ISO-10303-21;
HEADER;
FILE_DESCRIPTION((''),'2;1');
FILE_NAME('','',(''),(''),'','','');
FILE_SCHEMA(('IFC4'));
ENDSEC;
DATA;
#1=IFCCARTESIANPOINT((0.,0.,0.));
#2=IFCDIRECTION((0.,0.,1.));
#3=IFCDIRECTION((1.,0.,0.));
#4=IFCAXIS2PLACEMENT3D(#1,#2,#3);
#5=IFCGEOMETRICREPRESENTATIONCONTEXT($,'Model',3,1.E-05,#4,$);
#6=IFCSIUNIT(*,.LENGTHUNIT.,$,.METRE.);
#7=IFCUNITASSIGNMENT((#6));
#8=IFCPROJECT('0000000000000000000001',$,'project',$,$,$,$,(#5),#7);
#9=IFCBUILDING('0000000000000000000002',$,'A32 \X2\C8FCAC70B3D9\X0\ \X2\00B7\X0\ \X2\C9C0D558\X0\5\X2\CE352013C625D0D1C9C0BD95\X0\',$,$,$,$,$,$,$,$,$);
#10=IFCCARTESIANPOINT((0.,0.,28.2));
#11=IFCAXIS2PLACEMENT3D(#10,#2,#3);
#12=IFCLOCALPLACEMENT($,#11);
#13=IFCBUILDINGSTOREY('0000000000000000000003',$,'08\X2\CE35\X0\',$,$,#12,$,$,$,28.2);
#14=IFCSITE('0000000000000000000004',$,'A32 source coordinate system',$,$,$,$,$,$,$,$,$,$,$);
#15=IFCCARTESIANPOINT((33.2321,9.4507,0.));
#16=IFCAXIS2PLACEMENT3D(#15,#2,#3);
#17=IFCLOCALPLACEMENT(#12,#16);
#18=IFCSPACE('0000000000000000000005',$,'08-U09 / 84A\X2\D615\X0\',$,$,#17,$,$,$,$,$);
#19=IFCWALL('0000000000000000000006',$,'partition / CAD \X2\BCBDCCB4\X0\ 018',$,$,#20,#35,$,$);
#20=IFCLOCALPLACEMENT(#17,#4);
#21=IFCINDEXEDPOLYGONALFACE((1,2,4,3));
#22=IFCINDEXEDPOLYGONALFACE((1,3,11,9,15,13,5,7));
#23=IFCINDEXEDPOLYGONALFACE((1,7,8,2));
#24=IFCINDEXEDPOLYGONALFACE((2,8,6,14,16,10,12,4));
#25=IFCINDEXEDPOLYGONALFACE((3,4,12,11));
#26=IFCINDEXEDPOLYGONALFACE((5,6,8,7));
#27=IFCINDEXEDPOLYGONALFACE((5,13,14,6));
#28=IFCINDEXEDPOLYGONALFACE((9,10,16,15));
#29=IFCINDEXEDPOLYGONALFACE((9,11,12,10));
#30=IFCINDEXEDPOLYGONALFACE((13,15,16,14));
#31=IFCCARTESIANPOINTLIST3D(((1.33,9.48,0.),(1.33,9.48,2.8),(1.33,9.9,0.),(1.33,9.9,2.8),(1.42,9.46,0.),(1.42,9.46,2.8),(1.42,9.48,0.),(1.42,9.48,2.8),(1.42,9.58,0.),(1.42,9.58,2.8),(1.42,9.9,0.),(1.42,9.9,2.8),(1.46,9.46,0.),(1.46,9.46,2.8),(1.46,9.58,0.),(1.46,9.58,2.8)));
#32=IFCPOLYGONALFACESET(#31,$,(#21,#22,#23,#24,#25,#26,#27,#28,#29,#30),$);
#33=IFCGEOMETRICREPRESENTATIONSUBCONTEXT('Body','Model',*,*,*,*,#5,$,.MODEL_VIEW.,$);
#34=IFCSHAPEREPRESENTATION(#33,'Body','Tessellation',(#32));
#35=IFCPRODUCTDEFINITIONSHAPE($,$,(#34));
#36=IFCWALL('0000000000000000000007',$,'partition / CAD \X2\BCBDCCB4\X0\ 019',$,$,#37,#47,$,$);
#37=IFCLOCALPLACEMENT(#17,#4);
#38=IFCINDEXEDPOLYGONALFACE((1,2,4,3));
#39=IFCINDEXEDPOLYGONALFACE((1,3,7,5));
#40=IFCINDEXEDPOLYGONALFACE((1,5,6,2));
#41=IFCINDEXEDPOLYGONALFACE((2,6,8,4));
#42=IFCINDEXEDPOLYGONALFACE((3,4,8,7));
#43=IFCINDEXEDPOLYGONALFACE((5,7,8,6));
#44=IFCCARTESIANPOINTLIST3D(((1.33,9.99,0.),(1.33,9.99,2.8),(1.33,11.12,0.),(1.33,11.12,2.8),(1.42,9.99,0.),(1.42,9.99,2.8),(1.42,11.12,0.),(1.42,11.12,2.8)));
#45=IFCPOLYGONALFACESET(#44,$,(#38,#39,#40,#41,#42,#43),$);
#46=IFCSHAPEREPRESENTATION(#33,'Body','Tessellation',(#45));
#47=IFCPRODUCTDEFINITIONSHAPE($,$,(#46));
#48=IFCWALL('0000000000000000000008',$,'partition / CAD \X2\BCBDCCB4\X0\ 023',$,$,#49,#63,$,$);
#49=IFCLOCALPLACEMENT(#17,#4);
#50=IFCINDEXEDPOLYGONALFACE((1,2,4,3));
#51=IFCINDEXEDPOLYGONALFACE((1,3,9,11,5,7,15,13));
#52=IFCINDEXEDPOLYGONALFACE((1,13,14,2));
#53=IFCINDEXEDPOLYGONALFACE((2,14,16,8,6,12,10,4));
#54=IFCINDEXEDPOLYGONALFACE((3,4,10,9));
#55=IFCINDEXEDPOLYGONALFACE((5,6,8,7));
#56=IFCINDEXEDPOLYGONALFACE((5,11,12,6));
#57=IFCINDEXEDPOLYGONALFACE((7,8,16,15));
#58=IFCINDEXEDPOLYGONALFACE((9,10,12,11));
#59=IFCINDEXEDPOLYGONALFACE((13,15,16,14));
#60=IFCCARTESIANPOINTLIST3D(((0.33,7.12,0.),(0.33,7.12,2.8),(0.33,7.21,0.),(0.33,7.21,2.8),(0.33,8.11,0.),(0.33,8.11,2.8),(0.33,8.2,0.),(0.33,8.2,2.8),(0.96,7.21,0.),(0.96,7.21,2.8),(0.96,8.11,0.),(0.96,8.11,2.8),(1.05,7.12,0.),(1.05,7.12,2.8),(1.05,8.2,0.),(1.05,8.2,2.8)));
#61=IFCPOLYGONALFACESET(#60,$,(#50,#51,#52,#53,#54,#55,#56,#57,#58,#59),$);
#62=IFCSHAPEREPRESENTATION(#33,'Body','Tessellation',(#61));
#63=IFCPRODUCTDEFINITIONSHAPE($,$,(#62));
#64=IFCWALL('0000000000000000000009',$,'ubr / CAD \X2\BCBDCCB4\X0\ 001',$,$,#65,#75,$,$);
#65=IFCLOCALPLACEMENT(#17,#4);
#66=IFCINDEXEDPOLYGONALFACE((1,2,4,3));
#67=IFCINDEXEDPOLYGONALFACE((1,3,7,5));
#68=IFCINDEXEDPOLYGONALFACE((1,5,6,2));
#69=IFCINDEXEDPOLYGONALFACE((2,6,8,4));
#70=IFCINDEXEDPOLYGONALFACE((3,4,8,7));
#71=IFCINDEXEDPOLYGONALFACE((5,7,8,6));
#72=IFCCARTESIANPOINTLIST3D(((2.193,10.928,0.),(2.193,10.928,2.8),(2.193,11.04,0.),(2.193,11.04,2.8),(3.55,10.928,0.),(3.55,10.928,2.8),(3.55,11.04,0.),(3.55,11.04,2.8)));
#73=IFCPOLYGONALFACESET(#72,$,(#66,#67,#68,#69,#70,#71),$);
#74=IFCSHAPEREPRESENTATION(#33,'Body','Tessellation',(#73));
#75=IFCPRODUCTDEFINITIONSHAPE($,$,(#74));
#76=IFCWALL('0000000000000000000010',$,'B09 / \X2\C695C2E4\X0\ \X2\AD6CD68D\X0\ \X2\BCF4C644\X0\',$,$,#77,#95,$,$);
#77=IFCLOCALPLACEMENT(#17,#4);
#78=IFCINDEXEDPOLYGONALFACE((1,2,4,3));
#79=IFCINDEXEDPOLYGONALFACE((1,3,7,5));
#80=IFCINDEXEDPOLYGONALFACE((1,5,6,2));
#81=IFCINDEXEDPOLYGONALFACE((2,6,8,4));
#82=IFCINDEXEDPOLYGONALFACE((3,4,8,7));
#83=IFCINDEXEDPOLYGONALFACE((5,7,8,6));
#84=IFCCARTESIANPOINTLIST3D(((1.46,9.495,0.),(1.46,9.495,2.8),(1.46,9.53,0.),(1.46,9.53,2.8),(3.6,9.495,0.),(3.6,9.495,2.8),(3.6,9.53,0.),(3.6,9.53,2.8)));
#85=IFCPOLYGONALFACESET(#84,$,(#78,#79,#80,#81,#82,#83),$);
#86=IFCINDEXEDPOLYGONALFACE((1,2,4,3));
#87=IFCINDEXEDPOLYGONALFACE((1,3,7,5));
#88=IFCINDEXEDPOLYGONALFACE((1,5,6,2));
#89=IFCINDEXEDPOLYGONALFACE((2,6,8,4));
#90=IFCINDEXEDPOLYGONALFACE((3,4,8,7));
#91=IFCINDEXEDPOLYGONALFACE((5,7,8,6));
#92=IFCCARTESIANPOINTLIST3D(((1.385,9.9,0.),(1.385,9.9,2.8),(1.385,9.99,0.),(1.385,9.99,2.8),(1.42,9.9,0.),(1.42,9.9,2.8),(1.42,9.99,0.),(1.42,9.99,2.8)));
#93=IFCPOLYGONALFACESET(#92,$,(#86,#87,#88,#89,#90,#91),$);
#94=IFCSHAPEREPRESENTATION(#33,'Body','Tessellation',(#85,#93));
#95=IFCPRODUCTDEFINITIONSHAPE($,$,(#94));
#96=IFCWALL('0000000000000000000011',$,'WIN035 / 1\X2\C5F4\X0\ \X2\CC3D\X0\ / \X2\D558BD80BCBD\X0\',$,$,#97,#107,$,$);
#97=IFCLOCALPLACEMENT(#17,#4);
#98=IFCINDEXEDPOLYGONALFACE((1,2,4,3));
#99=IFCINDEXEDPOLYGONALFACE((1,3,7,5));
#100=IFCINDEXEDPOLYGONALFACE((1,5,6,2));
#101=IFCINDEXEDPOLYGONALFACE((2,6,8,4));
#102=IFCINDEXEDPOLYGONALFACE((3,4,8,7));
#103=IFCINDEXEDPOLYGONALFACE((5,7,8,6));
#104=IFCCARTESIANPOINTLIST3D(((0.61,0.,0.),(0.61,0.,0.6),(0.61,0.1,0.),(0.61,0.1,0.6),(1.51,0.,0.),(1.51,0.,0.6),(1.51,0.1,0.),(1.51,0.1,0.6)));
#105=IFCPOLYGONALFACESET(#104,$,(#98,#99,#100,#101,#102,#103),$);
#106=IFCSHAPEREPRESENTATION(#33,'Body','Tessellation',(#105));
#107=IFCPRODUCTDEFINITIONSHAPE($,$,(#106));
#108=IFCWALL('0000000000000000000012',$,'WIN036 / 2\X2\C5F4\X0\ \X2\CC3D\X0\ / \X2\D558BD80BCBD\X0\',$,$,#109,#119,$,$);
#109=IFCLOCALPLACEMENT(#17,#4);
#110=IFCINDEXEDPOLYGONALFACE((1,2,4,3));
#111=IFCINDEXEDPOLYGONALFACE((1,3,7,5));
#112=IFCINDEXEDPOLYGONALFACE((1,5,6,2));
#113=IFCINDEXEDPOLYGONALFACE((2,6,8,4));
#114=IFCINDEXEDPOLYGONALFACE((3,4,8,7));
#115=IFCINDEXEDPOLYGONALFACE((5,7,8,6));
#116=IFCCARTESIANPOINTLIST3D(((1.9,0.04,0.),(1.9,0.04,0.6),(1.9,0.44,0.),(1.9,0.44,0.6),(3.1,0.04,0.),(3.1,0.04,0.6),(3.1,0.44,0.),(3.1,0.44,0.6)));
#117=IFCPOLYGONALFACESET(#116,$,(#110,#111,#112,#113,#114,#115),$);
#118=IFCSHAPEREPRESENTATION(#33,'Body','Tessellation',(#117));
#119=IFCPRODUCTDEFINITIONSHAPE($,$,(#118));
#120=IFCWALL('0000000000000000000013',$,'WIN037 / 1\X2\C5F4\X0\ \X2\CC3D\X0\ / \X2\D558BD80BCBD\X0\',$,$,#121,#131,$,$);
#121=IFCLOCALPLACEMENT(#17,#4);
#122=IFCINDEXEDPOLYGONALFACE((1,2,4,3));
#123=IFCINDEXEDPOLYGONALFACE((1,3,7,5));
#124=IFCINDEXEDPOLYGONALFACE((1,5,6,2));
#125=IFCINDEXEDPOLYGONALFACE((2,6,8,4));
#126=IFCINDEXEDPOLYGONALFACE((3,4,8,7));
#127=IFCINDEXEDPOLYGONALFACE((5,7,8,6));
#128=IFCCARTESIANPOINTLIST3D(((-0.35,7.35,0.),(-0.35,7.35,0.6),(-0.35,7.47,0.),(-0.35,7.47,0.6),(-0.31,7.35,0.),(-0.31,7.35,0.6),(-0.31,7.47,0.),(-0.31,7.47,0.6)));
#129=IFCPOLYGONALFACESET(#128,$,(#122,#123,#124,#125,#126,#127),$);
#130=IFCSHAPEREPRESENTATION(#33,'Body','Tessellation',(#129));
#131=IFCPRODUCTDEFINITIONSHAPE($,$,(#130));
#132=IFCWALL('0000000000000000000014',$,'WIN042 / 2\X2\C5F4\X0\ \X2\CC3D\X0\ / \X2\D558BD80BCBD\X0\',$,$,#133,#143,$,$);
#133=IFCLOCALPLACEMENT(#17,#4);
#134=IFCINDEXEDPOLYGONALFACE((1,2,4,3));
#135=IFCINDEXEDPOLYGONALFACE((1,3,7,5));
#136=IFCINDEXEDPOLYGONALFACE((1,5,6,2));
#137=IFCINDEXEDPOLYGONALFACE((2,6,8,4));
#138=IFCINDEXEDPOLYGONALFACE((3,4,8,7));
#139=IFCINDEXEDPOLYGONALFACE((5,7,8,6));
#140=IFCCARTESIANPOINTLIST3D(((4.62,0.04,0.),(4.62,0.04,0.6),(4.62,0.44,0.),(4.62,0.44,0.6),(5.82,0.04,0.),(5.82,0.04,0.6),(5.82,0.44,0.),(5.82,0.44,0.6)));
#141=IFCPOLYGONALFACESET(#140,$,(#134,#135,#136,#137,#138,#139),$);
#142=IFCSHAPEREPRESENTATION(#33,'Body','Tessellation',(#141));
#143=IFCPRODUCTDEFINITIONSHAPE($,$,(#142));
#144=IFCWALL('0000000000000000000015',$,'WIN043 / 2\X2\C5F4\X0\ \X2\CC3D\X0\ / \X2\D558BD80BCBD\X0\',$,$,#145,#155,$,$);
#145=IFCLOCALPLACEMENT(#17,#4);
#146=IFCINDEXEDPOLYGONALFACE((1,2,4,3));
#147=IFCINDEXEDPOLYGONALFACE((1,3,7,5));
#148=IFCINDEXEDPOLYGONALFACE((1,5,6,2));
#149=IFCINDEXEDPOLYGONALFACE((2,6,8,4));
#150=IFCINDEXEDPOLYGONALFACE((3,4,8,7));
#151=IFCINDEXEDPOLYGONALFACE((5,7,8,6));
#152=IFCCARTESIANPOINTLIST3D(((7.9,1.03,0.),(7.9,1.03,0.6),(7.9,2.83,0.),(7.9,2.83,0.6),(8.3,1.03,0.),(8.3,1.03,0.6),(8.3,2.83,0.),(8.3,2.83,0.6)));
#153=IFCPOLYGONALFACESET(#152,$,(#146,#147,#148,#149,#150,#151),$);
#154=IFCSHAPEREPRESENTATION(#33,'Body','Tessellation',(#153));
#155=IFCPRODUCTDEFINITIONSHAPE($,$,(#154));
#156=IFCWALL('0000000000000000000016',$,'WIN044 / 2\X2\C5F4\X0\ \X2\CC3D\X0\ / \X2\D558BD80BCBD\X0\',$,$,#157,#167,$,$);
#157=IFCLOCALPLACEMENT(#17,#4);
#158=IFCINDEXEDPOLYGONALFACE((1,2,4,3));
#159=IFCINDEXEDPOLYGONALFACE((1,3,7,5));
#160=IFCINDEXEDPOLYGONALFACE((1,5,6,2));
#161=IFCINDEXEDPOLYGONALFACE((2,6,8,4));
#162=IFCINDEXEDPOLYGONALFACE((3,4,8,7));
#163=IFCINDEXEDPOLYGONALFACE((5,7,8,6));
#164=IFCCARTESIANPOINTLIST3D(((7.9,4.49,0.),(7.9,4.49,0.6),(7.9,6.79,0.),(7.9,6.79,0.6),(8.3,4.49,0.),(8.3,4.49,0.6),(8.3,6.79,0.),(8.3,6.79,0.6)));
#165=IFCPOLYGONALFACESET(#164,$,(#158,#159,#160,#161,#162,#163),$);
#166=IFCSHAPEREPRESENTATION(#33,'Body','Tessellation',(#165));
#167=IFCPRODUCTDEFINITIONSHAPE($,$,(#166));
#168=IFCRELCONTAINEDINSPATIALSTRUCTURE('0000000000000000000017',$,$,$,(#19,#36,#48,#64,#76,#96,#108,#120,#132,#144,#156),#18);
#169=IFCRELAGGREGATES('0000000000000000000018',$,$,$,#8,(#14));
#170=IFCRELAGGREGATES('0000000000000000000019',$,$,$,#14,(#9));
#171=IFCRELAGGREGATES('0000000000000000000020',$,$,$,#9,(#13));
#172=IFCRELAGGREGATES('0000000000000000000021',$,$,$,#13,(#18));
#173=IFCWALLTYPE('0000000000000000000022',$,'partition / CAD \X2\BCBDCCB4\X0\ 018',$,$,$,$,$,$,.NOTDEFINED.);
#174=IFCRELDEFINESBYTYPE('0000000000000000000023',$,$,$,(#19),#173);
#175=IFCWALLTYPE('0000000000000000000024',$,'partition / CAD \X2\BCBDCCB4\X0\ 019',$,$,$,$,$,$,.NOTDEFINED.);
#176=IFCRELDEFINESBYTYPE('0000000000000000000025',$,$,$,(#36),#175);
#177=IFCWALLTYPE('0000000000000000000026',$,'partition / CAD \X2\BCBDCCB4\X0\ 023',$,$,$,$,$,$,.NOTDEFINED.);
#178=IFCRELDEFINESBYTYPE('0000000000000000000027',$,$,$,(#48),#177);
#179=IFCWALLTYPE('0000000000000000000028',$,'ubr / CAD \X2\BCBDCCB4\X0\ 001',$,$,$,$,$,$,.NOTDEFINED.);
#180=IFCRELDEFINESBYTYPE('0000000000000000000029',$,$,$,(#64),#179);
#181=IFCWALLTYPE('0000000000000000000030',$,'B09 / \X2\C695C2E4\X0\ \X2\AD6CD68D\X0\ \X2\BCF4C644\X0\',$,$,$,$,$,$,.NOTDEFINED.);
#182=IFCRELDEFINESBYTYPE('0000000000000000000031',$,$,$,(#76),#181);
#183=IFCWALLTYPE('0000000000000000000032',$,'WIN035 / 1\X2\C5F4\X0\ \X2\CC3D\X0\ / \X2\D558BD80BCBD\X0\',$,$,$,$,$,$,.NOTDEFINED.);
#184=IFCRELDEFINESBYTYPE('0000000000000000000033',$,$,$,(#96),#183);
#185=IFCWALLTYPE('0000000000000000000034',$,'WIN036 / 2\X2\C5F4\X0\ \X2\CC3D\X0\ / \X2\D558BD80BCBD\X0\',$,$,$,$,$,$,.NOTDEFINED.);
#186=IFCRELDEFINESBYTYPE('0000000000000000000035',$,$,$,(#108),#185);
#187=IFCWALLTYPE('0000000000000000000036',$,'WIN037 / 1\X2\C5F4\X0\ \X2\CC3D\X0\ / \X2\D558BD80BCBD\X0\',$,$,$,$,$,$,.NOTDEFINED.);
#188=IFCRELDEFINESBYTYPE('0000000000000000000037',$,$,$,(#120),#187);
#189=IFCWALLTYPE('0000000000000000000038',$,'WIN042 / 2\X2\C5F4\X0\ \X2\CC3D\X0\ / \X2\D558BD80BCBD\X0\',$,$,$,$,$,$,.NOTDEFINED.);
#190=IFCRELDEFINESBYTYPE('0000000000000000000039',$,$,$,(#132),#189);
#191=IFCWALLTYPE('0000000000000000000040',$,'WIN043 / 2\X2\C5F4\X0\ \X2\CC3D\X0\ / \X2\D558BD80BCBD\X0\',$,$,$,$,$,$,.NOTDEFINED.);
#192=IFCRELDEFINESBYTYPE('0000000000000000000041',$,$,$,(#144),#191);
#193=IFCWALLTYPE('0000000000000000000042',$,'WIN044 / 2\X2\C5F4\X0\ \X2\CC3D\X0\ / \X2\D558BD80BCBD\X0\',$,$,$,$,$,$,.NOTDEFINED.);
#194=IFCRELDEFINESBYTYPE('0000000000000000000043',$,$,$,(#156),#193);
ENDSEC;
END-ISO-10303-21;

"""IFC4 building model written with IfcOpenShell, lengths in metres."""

from ifc_helpers import new_model, si_unit, frame, origin, origin_with_axes, place, context, subcontext, project, spatial, polyline, outline, extrude, source, transform, mapped, type_object, type_shapes, element, save


model = new_model("IFC4")

# Units and contexts
model_context = context("Model", 3, precision=1e-05, world=origin_with_axes())
body_context = subcontext(model_context, "Body", "Model", "MODEL_VIEW")
ifc_project = project(units=[si_unit("LENGTHUNIT", "METRE")], contexts=[model_context])

# Site, building, storey, space
site = spatial("IfcSite", under=ifc_project, Name="A32 source coordinate system")
building = spatial("IfcBuilding", under=site, Name="A32 주거동 · 지하5층–옥탑지붕")
storey_placement = place(None, frame((0.0, 0.0, 28.2), z_axis=(0.0, 0.0, 1.0), x_axis=(1.0, 0.0, 0.0)))
storey = spatial("IfcBuildingStorey", under=building, at=storey_placement, Name="08층", Elevation=28.2)
space_1_placement = place(storey_placement, frame((33.2321, 9.4507, 0.0), z_axis=(0.0, 0.0, 1.0), x_axis=(1.0, 0.0, 0.0)))
space_1 = spatial("IfcSpace", under=storey, at=space_1_placement, Name="08-U09 / 84A형")

# Walls
wall_type_1 = type_object("IfcWallType", Name="partition / CAD 벽체 018", PredefinedType="NOTDEFINED")
shared_shape_1 = source(origin(), body_context, "Body", "SweptSolid", [
    extrude(outline(polyline([(1.42, 9.58), (1.46, 9.58), (1.46, 9.46), (1.42, 9.46), (1.42, 9.48), (1.33, 9.48), (1.33, 9.9), (1.42, 9.9), (1.42, 9.58)])), origin(), (0.0, 0.0, 1.0), 2.8),
])
type_shapes(wall_type_1, [shared_shape_1])
wall_1_placement = place(space_1_placement, origin_with_axes())
element("IfcWall", 1, at=wall_1_placement, inside=space_1, type_object=wall_type_1, Name="partition / CAD 벽체 018", context=body_context, shape_type="MappedRepresentation", body=[
    mapped(shared_shape_1, transform((0.0, 0.0, 0.0), scale=1.0)),
])
wall_type_2 = type_object("IfcWallType", Name="partition / CAD 벽체 019", PredefinedType="NOTDEFINED")
shared_shape_2 = source(origin(), body_context, "Body", "SweptSolid", [
    extrude(outline(polyline([(1.33, 11.12), (1.42, 11.12), (1.42, 9.99), (1.33, 9.99), (1.33, 11.12)])), origin(), (0.0, 0.0, 1.0), 2.8),
])
type_shapes(wall_type_2, [shared_shape_2])
wall_2_placement = place(space_1_placement, origin_with_axes())
element("IfcWall", 2, at=wall_2_placement, inside=space_1, type_object=wall_type_2, Name="partition / CAD 벽체 019", context=body_context, shape_type="MappedRepresentation", body=[
    mapped(shared_shape_2, transform((0.0, 0.0, 0.0), scale=1.0)),
])
wall_type_3 = type_object("IfcWallType", Name="partition / CAD 벽체 023", PredefinedType="NOTDEFINED")
shared_shape_3 = source(origin(), body_context, "Body", "SweptSolid", [
    extrude(outline(polyline([(0.96, 8.11), (0.33, 8.11), (0.33, 8.2), (1.05, 8.2), (1.05, 7.12), (0.33, 7.12), (0.33, 7.21), (0.96, 7.21), (0.96, 8.11)])), origin(), (0.0, 0.0, 1.0), 2.8),
])
type_shapes(wall_type_3, [shared_shape_3])
wall_3_placement = place(space_1_placement, origin_with_axes())
element("IfcWall", 3, at=wall_3_placement, inside=space_1, type_object=wall_type_3, Name="partition / CAD 벽체 023", context=body_context, shape_type="MappedRepresentation", body=[
    mapped(shared_shape_3, transform((0.0, 0.0, 0.0), scale=1.0)),
])
wall_type_4 = type_object("IfcWallType", Name="ubr / CAD 벽체 001", PredefinedType="NOTDEFINED")
shared_shape_4 = source(origin(), body_context, "Body", "SweptSolid", [
    extrude(outline(polyline([(3.55, 11.04), (3.55, 10.928), (2.193, 10.928), (2.193, 11.04), (3.55, 11.04)])), origin(), (0.0, 0.0, 1.0), 2.8),
])
type_shapes(wall_type_4, [shared_shape_4])
wall_4_placement = place(space_1_placement, origin_with_axes())
element("IfcWall", 4, at=wall_4_placement, inside=space_1, type_object=wall_type_4, Name="ubr / CAD 벽체 001", context=body_context, shape_type="MappedRepresentation", body=[
    mapped(shared_shape_4, transform((0.0, 0.0, 0.0), scale=1.0)),
])
wall_type_5 = type_object("IfcWallType", Name="B09 / 욕실 구획 보완", PredefinedType="NOTDEFINED")
shared_shape_5 = source(origin(), body_context, "Body", "SweptSolid", [
    extrude(outline(polyline([(3.6, 9.53), (3.6, 9.495), (1.46, 9.495), (1.46, 9.53), (3.6, 9.53)])), origin(), (0.0, 0.0, 1.0), 2.8),
    extrude(outline(polyline([(1.42, 9.9), (1.385, 9.9), (1.385, 9.99), (1.42, 9.99), (1.42, 9.9)])), origin(), (0.0, 0.0, 1.0), 2.8),
])
type_shapes(wall_type_5, [shared_shape_5])
wall_5_placement = place(space_1_placement, origin_with_axes())
element("IfcWall", 5, at=wall_5_placement, inside=space_1, type_object=wall_type_5, Name="B09 / 욕실 구획 보완", context=body_context, shape_type="MappedRepresentation", body=[
    mapped(shared_shape_5, transform((0.0, 0.0, 0.0), scale=1.0)),
])
wall_type_6 = type_object("IfcWallType", Name="WIN035 / 1열 창 / 하부벽", PredefinedType="NOTDEFINED")
shared_shape_6 = source(origin(), body_context, "Body", "SweptSolid", [
    extrude(outline(polyline([(0.61, 0.1), (1.51, 0.1), (1.51, 0.0), (0.61, 0.0), (0.61, 0.1)])), origin(), (0.0, 0.0, 1.0), 0.6),
])
type_shapes(wall_type_6, [shared_shape_6])
wall_6_placement = place(space_1_placement, origin_with_axes())
element("IfcWall", 6, at=wall_6_placement, inside=space_1, type_object=wall_type_6, Name="WIN035 / 1열 창 / 하부벽", context=body_context, shape_type="MappedRepresentation", body=[
    mapped(shared_shape_6, transform((0.0, 0.0, 0.0), scale=1.0)),
])
wall_type_7 = type_object("IfcWallType", Name="WIN036 / 2열 창 / 하부벽", PredefinedType="NOTDEFINED")
shared_shape_7 = source(origin(), body_context, "Body", "SweptSolid", [
    extrude(outline(polyline([(1.9, 0.44), (3.1, 0.44), (3.1, 0.04), (1.9, 0.04), (1.9, 0.44)])), origin(), (0.0, 0.0, 1.0), 0.6),
])
type_shapes(wall_type_7, [shared_shape_7])
wall_7_placement = place(space_1_placement, origin_with_axes())
element("IfcWall", 7, at=wall_7_placement, inside=space_1, type_object=wall_type_7, Name="WIN036 / 2열 창 / 하부벽", context=body_context, shape_type="MappedRepresentation", body=[
    mapped(shared_shape_7, transform((0.0, 0.0, 0.0), scale=1.0)),
])
wall_type_8 = type_object("IfcWallType", Name="WIN037 / 1열 창 / 하부벽", PredefinedType="NOTDEFINED")
shared_shape_8 = source(origin(), body_context, "Body", "SweptSolid", [
    extrude(outline(polyline([(-0.31, 7.47), (-0.31, 7.35), (-0.35, 7.35), (-0.35, 7.47), (-0.31, 7.47)])), origin(), (0.0, 0.0, 1.0), 0.6),
])
type_shapes(wall_type_8, [shared_shape_8])
wall_8_placement = place(space_1_placement, origin_with_axes())
element("IfcWall", 8, at=wall_8_placement, inside=space_1, type_object=wall_type_8, Name="WIN037 / 1열 창 / 하부벽", context=body_context, shape_type="MappedRepresentation", body=[
    mapped(shared_shape_8, transform((0.0, 0.0, 0.0), scale=1.0)),
])
wall_type_9 = type_object("IfcWallType", Name="WIN042 / 2열 창 / 하부벽", PredefinedType="NOTDEFINED")
shared_shape_9 = source(origin(), body_context, "Body", "SweptSolid", [
    extrude(outline(polyline([(4.62, 0.44), (5.82, 0.44), (5.82, 0.04), (4.62, 0.04), (4.62, 0.44)])), origin(), (0.0, 0.0, 1.0), 0.6),
])
type_shapes(wall_type_9, [shared_shape_9])
wall_9_placement = place(space_1_placement, origin_with_axes())
element("IfcWall", 9, at=wall_9_placement, inside=space_1, type_object=wall_type_9, Name="WIN042 / 2열 창 / 하부벽", context=body_context, shape_type="MappedRepresentation", body=[
    mapped(shared_shape_9, transform((0.0, 0.0, 0.0), scale=1.0)),
])
wall_type_10 = type_object("IfcWallType", Name="WIN043 / 2열 창 / 하부벽", PredefinedType="NOTDEFINED")
shared_shape_10 = source(origin(), body_context, "Body", "SweptSolid", [
    extrude(outline(polyline([(7.9, 2.83), (8.3, 2.83), (8.3, 1.03), (7.9, 1.03), (7.9, 2.83)])), origin(), (0.0, 0.0, 1.0), 0.6),
])
type_shapes(wall_type_10, [shared_shape_10])
wall_10_placement = place(space_1_placement, origin_with_axes())
element("IfcWall", 10, at=wall_10_placement, inside=space_1, type_object=wall_type_10, Name="WIN043 / 2열 창 / 하부벽", context=body_context, shape_type="MappedRepresentation", body=[
    mapped(shared_shape_10, transform((0.0, 0.0, 0.0), scale=1.0)),
])
wall_type_11 = type_object("IfcWallType", Name="WIN044 / 2열 창 / 하부벽", PredefinedType="NOTDEFINED")
shared_shape_11 = source(origin(), body_context, "Body", "SweptSolid", [
    extrude(outline(polyline([(7.9, 6.79), (8.3, 6.79), (8.3, 4.49), (7.9, 4.49), (7.9, 6.79)])), origin(), (0.0, 0.0, 1.0), 0.6),
])
type_shapes(wall_type_11, [shared_shape_11])
wall_11_placement = place(space_1_placement, origin_with_axes())
element("IfcWall", 11, at=wall_11_placement, inside=space_1, type_object=wall_type_11, Name="WIN044 / 2열 창 / 하부벽", context=body_context, shape_type="MappedRepresentation", body=[
    mapped(shared_shape_11, transform((0.0, 0.0, 0.0), scale=1.0)),
])

save(model, "model.ifc")
